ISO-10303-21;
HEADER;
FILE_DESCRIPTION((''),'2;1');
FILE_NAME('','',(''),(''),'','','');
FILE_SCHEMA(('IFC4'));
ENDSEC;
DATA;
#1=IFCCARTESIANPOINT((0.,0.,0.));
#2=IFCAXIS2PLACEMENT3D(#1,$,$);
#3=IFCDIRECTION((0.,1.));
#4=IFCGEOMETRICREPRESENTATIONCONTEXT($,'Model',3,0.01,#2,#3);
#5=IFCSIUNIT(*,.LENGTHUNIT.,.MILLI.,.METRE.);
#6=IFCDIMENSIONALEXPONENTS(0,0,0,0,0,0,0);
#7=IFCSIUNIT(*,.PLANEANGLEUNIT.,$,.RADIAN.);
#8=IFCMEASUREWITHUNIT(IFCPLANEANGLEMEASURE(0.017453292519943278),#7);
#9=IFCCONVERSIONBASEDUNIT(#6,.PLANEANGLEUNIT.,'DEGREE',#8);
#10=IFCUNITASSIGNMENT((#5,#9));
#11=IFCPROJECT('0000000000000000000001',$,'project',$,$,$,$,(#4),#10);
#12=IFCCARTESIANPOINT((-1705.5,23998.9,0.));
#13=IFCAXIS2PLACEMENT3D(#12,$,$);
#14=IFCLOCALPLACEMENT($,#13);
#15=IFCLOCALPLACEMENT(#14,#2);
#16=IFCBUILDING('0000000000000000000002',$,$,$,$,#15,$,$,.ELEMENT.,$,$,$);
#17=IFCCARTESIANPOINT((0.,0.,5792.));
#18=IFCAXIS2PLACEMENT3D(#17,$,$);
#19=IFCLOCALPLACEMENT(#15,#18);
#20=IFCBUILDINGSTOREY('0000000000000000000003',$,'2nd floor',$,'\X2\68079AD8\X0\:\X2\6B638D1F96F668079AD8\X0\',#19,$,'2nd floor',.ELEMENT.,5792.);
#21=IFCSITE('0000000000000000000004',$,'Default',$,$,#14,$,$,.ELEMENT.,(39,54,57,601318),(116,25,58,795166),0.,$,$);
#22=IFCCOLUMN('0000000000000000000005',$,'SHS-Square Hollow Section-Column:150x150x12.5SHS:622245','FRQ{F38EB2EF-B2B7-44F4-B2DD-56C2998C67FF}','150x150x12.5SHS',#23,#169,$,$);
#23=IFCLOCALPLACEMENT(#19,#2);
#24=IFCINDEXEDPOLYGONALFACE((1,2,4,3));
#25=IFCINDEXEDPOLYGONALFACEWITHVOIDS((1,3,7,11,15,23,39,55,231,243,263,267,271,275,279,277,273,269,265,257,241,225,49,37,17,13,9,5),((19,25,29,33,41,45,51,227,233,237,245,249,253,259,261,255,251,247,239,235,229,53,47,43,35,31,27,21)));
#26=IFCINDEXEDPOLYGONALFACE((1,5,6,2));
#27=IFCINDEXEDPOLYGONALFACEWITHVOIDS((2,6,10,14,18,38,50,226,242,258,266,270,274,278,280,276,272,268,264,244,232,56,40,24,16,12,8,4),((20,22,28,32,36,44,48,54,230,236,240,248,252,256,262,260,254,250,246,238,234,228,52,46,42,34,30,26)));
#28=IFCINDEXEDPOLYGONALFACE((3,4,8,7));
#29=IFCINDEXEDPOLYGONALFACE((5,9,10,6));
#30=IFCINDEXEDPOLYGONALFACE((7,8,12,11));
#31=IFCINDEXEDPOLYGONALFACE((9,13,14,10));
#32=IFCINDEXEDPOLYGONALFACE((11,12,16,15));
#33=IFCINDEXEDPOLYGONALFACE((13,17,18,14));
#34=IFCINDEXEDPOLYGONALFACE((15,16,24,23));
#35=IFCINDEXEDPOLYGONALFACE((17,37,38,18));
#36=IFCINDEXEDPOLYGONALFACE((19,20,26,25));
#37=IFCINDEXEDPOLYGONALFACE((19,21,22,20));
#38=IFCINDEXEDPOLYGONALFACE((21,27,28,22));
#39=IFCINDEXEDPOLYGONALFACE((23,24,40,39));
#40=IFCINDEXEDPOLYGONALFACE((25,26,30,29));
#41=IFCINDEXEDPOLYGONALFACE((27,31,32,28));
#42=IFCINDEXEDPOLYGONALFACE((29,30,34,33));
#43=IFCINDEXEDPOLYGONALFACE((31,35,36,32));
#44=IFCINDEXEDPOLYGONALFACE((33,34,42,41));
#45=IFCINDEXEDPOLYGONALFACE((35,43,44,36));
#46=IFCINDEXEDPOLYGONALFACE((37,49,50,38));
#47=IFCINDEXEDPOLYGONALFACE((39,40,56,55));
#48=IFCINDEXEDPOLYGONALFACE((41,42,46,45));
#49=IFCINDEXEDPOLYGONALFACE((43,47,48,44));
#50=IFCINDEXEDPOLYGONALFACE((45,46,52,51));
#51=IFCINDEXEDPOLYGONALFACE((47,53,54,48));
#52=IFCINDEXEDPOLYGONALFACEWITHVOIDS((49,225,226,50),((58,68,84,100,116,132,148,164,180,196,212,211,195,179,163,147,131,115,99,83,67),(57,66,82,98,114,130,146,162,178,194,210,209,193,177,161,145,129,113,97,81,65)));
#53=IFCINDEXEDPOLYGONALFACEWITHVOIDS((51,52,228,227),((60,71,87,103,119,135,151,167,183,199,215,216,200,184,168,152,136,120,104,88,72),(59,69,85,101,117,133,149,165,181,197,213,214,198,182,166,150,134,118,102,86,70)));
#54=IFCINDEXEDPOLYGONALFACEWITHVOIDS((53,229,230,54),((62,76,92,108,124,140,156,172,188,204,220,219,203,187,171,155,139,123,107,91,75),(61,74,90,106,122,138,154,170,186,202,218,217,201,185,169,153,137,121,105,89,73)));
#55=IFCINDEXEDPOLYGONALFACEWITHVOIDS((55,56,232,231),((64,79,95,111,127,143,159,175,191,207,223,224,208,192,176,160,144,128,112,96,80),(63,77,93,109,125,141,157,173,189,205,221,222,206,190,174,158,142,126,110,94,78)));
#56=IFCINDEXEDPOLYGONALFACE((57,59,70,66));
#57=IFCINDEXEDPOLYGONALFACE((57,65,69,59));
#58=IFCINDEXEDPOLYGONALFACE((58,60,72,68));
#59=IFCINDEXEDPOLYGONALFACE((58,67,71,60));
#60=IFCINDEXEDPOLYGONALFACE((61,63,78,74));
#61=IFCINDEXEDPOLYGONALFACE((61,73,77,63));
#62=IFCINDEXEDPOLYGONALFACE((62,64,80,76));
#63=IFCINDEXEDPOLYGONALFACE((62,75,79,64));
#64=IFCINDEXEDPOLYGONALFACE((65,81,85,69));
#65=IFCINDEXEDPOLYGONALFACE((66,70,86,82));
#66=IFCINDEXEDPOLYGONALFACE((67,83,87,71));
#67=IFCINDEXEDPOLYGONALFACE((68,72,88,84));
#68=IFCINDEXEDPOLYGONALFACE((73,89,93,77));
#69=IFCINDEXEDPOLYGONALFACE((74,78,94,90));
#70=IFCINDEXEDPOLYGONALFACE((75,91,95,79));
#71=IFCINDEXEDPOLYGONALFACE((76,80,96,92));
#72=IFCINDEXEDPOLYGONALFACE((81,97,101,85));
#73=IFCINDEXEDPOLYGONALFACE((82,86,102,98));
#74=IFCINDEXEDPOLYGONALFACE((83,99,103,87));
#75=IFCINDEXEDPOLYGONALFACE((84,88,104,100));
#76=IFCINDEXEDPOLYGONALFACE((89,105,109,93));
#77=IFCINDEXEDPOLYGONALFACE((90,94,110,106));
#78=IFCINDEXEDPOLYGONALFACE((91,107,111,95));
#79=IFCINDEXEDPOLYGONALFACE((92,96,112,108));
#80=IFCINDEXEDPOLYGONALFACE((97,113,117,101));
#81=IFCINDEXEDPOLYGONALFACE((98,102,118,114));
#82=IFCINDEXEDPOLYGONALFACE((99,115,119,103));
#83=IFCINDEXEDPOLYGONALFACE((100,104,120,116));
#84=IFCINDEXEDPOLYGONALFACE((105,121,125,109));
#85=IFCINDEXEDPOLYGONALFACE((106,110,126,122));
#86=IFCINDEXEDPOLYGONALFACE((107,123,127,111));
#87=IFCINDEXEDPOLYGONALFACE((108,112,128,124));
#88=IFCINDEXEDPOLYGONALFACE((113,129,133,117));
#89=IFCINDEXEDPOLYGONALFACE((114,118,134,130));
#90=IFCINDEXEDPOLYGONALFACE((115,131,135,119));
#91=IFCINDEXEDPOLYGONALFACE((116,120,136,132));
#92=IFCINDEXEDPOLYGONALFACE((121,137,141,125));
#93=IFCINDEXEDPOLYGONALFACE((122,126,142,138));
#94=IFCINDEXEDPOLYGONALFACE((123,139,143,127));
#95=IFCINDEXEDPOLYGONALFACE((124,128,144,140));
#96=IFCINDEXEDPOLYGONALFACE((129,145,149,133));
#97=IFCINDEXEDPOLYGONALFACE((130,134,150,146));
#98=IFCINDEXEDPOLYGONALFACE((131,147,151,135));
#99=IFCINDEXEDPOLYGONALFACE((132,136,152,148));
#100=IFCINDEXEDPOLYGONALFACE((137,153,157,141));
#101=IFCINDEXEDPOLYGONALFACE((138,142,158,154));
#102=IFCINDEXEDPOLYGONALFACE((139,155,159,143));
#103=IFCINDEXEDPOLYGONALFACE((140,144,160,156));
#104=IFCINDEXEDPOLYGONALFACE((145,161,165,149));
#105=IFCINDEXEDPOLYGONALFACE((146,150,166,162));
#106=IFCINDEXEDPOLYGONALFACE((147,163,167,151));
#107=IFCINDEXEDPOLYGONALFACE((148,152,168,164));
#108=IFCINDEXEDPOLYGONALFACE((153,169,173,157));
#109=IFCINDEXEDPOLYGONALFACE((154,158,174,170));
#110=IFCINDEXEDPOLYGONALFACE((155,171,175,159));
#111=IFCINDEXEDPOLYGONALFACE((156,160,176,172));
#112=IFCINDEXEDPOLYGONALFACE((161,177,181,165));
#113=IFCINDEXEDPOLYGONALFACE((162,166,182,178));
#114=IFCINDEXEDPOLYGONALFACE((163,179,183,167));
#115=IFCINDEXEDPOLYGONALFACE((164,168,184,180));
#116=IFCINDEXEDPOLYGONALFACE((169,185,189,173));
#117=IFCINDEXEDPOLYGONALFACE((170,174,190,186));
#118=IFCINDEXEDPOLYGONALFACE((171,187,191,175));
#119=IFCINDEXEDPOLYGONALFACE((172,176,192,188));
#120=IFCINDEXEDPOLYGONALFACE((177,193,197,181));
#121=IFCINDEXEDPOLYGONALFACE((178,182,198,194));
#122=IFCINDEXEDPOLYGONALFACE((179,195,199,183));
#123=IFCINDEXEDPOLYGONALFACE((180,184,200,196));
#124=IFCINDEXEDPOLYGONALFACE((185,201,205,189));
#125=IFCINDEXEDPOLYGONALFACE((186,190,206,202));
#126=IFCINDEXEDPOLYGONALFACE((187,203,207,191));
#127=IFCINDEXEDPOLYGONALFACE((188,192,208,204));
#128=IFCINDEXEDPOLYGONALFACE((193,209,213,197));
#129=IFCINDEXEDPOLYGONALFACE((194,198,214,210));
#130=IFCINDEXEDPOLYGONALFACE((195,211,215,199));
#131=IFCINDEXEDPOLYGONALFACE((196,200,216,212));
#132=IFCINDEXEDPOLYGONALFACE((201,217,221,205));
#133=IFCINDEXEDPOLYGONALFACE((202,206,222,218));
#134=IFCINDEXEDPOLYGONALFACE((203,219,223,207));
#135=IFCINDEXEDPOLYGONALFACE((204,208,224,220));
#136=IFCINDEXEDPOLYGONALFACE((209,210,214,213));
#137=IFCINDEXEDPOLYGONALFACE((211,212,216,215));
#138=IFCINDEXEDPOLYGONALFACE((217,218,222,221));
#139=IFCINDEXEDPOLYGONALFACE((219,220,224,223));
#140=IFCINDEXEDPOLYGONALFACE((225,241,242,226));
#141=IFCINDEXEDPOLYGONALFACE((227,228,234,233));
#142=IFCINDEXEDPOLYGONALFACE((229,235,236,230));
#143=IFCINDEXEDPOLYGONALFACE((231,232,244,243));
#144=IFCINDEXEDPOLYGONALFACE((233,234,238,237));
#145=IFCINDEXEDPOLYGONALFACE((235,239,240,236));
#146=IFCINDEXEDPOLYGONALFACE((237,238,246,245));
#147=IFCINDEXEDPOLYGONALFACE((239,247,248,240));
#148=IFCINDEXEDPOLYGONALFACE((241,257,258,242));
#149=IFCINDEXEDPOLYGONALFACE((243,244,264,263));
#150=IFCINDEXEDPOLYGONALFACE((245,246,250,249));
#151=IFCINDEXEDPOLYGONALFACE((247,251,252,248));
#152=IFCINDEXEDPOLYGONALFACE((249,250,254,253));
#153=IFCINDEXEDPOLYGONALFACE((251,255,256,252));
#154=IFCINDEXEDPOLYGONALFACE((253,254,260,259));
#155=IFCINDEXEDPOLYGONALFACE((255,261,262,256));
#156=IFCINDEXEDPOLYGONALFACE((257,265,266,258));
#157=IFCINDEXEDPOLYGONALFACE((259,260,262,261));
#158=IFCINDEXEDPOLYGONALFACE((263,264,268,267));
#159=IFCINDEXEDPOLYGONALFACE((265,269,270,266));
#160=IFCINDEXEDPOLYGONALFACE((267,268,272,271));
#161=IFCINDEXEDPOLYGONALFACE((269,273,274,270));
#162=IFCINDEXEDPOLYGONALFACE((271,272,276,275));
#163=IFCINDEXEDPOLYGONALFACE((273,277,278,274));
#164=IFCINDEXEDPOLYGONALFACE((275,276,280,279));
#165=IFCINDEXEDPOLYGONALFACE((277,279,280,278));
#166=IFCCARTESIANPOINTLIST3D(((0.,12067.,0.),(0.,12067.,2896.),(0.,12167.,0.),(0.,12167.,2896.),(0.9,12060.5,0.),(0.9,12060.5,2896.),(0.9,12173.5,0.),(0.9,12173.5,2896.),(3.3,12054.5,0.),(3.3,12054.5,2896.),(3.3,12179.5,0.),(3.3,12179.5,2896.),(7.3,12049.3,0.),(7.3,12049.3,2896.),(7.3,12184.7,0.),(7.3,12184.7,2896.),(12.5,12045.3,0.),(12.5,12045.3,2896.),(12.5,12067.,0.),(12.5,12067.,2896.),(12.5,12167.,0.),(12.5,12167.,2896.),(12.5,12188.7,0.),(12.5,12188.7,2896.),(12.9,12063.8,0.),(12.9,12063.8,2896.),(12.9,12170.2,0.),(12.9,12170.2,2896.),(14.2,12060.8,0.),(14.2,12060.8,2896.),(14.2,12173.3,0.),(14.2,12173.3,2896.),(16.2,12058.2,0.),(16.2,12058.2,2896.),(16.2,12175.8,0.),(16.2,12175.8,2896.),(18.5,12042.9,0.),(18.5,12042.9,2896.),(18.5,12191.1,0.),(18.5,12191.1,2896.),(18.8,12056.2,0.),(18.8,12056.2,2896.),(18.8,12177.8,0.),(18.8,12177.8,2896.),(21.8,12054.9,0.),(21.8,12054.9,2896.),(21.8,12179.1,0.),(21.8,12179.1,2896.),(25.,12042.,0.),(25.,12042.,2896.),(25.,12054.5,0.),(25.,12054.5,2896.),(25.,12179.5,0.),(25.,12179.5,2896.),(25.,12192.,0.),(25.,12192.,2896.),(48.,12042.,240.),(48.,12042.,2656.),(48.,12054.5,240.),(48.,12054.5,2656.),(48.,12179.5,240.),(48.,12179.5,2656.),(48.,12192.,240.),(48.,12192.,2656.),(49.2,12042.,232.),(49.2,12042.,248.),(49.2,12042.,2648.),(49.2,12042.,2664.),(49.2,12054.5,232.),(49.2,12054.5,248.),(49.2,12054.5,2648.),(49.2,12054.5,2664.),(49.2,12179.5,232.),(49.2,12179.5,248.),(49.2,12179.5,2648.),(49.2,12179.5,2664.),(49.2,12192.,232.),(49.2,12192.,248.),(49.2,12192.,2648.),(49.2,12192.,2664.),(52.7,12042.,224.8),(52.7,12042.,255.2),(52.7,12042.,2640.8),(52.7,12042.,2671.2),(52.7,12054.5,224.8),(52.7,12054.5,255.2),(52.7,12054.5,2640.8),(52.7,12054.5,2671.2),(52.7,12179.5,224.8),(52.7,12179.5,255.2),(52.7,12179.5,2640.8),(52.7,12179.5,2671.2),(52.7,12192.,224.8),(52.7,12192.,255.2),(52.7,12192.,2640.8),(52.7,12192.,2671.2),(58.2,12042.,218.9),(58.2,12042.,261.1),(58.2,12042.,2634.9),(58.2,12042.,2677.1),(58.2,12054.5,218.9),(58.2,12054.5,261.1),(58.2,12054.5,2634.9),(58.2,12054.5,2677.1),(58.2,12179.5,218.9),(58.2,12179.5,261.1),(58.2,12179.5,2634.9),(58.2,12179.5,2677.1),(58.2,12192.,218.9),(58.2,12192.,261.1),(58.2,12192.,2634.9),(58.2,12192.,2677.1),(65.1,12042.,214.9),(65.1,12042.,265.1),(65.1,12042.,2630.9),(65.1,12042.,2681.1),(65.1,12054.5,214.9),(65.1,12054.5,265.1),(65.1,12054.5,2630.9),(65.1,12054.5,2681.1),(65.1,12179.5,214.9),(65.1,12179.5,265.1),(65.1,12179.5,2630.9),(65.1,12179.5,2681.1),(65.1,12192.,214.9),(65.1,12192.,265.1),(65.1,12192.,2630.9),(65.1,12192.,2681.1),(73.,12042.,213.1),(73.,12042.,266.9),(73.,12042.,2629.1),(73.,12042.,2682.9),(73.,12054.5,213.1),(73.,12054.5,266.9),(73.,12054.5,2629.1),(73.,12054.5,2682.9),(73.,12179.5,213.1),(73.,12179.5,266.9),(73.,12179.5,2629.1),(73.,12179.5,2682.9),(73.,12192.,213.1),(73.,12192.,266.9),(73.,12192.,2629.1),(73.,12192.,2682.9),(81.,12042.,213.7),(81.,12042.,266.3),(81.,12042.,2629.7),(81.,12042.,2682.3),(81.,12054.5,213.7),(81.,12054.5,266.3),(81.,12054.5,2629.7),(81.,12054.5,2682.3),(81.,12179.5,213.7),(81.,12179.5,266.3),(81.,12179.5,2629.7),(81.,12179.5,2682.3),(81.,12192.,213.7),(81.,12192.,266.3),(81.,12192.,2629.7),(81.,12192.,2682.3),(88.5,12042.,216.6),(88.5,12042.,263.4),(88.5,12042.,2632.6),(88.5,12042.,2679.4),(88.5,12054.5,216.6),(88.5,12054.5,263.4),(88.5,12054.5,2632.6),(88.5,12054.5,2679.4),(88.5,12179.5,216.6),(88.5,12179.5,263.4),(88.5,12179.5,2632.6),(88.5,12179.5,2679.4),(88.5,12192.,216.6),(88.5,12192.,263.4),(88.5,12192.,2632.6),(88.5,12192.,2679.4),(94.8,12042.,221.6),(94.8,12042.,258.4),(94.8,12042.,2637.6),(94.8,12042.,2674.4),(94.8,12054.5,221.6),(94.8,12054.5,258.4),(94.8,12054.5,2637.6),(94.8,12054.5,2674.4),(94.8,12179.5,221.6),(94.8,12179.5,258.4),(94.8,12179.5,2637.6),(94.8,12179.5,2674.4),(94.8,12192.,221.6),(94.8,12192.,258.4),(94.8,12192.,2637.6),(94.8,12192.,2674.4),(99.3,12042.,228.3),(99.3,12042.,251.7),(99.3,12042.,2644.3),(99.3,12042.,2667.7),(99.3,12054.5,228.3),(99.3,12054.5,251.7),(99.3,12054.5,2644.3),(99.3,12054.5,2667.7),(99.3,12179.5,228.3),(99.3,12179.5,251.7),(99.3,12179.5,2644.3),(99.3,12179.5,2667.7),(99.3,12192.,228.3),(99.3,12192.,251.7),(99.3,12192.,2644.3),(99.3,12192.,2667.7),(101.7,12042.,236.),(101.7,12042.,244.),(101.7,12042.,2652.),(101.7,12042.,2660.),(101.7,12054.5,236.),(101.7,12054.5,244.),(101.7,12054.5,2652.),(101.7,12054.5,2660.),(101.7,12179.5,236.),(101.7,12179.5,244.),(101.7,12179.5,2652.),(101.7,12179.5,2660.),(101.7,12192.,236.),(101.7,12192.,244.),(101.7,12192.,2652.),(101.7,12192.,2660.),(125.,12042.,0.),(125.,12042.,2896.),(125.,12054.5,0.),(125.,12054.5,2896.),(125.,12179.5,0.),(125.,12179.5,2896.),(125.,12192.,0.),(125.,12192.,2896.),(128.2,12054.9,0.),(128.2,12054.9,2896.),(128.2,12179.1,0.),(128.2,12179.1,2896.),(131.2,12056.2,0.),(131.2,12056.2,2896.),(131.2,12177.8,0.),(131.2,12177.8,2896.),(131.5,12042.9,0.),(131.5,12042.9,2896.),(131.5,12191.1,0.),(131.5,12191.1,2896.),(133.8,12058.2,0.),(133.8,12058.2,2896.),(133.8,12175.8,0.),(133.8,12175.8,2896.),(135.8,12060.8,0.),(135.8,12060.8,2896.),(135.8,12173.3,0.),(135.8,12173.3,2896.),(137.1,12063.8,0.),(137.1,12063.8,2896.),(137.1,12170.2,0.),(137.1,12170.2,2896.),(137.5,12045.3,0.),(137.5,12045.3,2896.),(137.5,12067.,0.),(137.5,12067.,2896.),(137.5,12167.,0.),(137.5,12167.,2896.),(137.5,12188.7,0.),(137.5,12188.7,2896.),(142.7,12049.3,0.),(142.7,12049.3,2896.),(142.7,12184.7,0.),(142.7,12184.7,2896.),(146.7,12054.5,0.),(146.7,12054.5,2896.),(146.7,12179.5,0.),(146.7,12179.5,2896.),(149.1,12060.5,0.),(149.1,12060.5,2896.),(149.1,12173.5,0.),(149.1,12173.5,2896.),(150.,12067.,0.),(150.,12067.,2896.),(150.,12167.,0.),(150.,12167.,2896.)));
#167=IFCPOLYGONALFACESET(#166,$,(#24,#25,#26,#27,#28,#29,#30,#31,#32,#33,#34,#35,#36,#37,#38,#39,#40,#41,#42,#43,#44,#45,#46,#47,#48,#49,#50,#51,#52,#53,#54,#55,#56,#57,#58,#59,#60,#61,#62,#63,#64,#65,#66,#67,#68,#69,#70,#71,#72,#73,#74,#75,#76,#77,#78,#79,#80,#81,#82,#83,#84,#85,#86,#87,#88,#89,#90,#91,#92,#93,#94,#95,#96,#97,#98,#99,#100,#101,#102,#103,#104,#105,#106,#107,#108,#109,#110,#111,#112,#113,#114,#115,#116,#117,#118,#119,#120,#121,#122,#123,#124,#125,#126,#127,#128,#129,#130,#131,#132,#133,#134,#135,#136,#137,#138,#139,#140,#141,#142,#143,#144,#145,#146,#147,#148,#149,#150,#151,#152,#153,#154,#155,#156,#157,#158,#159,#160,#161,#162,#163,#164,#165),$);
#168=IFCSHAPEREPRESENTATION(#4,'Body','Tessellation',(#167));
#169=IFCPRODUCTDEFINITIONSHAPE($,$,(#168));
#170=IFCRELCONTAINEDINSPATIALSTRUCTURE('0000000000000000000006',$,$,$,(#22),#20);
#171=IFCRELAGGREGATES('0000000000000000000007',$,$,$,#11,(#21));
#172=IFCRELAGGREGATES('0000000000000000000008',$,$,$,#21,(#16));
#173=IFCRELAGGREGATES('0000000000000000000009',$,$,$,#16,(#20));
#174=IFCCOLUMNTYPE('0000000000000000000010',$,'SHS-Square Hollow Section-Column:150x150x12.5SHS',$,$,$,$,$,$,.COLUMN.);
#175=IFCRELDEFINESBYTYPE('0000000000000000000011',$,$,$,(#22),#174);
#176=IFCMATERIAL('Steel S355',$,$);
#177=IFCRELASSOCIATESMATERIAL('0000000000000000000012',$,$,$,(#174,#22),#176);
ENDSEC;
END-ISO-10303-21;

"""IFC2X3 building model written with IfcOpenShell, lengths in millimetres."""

from ifc_helpers import new_model, entity, si_unit, converted_unit, direction, frame, frame_2d, origin, origin_2d, place, context, project, spatial, circle_curve, hollow_rectangle, outline, extrude, material, type_object, element, save


model = new_model("IFC2X3")

# Units and contexts
model_context = context("Model", 3, precision=0.01, world=origin(), true_north=direction((0.0, 1.0)))
ifc_project = project(units=[si_unit("LENGTHUNIT", "METRE", prefix="MILLI"), converted_unit("PLANEANGLEUNIT", "DEGREE", entity("IfcPlaneAngleMeasure", 0.017453292519943278), si_unit("PLANEANGLEUNIT", "RADIAN"), dimensions=[0, 0, 0, 0, 0, 0, 0])], contexts=[model_context])

# Site, building, storey
site_placement = place(None, frame((-1705.5, 23998.9, 0.0)))
site = spatial("IfcSite", under=ifc_project, at=site_placement, Name="Default", CompositionType="ELEMENT", RefLatitude=(39, 54, 57, 601318), RefLongitude=(116, 25, 58, 795166), RefElevation=0.0)
building_placement = place(site_placement, origin())
building = spatial("IfcBuilding", under=site, at=building_placement, CompositionType="ELEMENT")
storey_placement = place(building_placement, frame((0.0, 0.0, 5792.0)))
storey = spatial("IfcBuildingStorey", under=building, at=storey_placement, Name="2nd floor", ObjectType="标高:正负零标高", LongName="2nd floor", CompositionType="ELEMENT", Elevation=5792.0)

# Shared definitions
ifc_material_1 = material(Name="Steel S355")

# Column, openings
column_type_1 = type_object("IfcColumnType", Name="SHS-Square Hollow Section-Column:150x150x12.5SHS", PredefinedType="COLUMN", material=ifc_material_1)
column_1_placement = place(storey_placement, frame((75.0, 12117.0, 2896.0), z_axis=(0.0, 0.0, 1.0), x_axis=(0.0, -1.0, 0.0)))
column_1 = element("IfcColumn", 1, at=column_1_placement, inside=storey, type_object=column_type_1, material=ifc_material_1, Name="SHS-Square Hollow Section-Column:150x150x12.5SHS:622245", Description="FRQ{F38EB2EF-B2B7-44F4-B2DD-56C2998C67FF}", ObjectType="150x150x12.5SHS", context=model_context, shape_type="SweptSolid", body=[
    extrude(hollow_rectangle(XDim=150.0, YDim=150.0, WallThickness=12.5, InnerFilletRadius=12.5, OuterFilletRadius=25.0, at=origin_2d()), origin(), (0.0, 0.0, -1.0), 2896.0),
])
opening_1_placement = place(column_1_placement, frame((175.1, 0.0, -2896.0), z_axis=(-1.0, 0.0, 0.0), x_axis=(0.0, -1.0, 0.0)))
element("IfcOpeningElement", 2, at=opening_1_placement, cuts=column_1, ObjectType="Opening", context=model_context, shape_type="SweptSolid", body=[
    extrude(outline(circle_curve(frame_2d((0.0, 240.0), x_axis=(1.0, 0.0)), 27.0)), origin(), (0.0, 0.0, 1.0), 350.2),
])
opening_2_placement = place(column_1_placement, frame((175.1, 0.0, 0.0), z_axis=(-1.0, 0.0, 0.0), x_axis=(0.0, -1.0, 0.0)))
element("IfcOpeningElement", 3, at=opening_2_placement, cuts=column_1, ObjectType="Opening", context=model_context, shape_type="SweptSolid", body=[
    extrude(outline(circle_curve(frame_2d((0.0, -240.0), x_axis=(1.0, 0.0)), 27.0)), origin(), (0.0, 0.0, 1.0), 350.2),
])

save(model, "model.ifc")
